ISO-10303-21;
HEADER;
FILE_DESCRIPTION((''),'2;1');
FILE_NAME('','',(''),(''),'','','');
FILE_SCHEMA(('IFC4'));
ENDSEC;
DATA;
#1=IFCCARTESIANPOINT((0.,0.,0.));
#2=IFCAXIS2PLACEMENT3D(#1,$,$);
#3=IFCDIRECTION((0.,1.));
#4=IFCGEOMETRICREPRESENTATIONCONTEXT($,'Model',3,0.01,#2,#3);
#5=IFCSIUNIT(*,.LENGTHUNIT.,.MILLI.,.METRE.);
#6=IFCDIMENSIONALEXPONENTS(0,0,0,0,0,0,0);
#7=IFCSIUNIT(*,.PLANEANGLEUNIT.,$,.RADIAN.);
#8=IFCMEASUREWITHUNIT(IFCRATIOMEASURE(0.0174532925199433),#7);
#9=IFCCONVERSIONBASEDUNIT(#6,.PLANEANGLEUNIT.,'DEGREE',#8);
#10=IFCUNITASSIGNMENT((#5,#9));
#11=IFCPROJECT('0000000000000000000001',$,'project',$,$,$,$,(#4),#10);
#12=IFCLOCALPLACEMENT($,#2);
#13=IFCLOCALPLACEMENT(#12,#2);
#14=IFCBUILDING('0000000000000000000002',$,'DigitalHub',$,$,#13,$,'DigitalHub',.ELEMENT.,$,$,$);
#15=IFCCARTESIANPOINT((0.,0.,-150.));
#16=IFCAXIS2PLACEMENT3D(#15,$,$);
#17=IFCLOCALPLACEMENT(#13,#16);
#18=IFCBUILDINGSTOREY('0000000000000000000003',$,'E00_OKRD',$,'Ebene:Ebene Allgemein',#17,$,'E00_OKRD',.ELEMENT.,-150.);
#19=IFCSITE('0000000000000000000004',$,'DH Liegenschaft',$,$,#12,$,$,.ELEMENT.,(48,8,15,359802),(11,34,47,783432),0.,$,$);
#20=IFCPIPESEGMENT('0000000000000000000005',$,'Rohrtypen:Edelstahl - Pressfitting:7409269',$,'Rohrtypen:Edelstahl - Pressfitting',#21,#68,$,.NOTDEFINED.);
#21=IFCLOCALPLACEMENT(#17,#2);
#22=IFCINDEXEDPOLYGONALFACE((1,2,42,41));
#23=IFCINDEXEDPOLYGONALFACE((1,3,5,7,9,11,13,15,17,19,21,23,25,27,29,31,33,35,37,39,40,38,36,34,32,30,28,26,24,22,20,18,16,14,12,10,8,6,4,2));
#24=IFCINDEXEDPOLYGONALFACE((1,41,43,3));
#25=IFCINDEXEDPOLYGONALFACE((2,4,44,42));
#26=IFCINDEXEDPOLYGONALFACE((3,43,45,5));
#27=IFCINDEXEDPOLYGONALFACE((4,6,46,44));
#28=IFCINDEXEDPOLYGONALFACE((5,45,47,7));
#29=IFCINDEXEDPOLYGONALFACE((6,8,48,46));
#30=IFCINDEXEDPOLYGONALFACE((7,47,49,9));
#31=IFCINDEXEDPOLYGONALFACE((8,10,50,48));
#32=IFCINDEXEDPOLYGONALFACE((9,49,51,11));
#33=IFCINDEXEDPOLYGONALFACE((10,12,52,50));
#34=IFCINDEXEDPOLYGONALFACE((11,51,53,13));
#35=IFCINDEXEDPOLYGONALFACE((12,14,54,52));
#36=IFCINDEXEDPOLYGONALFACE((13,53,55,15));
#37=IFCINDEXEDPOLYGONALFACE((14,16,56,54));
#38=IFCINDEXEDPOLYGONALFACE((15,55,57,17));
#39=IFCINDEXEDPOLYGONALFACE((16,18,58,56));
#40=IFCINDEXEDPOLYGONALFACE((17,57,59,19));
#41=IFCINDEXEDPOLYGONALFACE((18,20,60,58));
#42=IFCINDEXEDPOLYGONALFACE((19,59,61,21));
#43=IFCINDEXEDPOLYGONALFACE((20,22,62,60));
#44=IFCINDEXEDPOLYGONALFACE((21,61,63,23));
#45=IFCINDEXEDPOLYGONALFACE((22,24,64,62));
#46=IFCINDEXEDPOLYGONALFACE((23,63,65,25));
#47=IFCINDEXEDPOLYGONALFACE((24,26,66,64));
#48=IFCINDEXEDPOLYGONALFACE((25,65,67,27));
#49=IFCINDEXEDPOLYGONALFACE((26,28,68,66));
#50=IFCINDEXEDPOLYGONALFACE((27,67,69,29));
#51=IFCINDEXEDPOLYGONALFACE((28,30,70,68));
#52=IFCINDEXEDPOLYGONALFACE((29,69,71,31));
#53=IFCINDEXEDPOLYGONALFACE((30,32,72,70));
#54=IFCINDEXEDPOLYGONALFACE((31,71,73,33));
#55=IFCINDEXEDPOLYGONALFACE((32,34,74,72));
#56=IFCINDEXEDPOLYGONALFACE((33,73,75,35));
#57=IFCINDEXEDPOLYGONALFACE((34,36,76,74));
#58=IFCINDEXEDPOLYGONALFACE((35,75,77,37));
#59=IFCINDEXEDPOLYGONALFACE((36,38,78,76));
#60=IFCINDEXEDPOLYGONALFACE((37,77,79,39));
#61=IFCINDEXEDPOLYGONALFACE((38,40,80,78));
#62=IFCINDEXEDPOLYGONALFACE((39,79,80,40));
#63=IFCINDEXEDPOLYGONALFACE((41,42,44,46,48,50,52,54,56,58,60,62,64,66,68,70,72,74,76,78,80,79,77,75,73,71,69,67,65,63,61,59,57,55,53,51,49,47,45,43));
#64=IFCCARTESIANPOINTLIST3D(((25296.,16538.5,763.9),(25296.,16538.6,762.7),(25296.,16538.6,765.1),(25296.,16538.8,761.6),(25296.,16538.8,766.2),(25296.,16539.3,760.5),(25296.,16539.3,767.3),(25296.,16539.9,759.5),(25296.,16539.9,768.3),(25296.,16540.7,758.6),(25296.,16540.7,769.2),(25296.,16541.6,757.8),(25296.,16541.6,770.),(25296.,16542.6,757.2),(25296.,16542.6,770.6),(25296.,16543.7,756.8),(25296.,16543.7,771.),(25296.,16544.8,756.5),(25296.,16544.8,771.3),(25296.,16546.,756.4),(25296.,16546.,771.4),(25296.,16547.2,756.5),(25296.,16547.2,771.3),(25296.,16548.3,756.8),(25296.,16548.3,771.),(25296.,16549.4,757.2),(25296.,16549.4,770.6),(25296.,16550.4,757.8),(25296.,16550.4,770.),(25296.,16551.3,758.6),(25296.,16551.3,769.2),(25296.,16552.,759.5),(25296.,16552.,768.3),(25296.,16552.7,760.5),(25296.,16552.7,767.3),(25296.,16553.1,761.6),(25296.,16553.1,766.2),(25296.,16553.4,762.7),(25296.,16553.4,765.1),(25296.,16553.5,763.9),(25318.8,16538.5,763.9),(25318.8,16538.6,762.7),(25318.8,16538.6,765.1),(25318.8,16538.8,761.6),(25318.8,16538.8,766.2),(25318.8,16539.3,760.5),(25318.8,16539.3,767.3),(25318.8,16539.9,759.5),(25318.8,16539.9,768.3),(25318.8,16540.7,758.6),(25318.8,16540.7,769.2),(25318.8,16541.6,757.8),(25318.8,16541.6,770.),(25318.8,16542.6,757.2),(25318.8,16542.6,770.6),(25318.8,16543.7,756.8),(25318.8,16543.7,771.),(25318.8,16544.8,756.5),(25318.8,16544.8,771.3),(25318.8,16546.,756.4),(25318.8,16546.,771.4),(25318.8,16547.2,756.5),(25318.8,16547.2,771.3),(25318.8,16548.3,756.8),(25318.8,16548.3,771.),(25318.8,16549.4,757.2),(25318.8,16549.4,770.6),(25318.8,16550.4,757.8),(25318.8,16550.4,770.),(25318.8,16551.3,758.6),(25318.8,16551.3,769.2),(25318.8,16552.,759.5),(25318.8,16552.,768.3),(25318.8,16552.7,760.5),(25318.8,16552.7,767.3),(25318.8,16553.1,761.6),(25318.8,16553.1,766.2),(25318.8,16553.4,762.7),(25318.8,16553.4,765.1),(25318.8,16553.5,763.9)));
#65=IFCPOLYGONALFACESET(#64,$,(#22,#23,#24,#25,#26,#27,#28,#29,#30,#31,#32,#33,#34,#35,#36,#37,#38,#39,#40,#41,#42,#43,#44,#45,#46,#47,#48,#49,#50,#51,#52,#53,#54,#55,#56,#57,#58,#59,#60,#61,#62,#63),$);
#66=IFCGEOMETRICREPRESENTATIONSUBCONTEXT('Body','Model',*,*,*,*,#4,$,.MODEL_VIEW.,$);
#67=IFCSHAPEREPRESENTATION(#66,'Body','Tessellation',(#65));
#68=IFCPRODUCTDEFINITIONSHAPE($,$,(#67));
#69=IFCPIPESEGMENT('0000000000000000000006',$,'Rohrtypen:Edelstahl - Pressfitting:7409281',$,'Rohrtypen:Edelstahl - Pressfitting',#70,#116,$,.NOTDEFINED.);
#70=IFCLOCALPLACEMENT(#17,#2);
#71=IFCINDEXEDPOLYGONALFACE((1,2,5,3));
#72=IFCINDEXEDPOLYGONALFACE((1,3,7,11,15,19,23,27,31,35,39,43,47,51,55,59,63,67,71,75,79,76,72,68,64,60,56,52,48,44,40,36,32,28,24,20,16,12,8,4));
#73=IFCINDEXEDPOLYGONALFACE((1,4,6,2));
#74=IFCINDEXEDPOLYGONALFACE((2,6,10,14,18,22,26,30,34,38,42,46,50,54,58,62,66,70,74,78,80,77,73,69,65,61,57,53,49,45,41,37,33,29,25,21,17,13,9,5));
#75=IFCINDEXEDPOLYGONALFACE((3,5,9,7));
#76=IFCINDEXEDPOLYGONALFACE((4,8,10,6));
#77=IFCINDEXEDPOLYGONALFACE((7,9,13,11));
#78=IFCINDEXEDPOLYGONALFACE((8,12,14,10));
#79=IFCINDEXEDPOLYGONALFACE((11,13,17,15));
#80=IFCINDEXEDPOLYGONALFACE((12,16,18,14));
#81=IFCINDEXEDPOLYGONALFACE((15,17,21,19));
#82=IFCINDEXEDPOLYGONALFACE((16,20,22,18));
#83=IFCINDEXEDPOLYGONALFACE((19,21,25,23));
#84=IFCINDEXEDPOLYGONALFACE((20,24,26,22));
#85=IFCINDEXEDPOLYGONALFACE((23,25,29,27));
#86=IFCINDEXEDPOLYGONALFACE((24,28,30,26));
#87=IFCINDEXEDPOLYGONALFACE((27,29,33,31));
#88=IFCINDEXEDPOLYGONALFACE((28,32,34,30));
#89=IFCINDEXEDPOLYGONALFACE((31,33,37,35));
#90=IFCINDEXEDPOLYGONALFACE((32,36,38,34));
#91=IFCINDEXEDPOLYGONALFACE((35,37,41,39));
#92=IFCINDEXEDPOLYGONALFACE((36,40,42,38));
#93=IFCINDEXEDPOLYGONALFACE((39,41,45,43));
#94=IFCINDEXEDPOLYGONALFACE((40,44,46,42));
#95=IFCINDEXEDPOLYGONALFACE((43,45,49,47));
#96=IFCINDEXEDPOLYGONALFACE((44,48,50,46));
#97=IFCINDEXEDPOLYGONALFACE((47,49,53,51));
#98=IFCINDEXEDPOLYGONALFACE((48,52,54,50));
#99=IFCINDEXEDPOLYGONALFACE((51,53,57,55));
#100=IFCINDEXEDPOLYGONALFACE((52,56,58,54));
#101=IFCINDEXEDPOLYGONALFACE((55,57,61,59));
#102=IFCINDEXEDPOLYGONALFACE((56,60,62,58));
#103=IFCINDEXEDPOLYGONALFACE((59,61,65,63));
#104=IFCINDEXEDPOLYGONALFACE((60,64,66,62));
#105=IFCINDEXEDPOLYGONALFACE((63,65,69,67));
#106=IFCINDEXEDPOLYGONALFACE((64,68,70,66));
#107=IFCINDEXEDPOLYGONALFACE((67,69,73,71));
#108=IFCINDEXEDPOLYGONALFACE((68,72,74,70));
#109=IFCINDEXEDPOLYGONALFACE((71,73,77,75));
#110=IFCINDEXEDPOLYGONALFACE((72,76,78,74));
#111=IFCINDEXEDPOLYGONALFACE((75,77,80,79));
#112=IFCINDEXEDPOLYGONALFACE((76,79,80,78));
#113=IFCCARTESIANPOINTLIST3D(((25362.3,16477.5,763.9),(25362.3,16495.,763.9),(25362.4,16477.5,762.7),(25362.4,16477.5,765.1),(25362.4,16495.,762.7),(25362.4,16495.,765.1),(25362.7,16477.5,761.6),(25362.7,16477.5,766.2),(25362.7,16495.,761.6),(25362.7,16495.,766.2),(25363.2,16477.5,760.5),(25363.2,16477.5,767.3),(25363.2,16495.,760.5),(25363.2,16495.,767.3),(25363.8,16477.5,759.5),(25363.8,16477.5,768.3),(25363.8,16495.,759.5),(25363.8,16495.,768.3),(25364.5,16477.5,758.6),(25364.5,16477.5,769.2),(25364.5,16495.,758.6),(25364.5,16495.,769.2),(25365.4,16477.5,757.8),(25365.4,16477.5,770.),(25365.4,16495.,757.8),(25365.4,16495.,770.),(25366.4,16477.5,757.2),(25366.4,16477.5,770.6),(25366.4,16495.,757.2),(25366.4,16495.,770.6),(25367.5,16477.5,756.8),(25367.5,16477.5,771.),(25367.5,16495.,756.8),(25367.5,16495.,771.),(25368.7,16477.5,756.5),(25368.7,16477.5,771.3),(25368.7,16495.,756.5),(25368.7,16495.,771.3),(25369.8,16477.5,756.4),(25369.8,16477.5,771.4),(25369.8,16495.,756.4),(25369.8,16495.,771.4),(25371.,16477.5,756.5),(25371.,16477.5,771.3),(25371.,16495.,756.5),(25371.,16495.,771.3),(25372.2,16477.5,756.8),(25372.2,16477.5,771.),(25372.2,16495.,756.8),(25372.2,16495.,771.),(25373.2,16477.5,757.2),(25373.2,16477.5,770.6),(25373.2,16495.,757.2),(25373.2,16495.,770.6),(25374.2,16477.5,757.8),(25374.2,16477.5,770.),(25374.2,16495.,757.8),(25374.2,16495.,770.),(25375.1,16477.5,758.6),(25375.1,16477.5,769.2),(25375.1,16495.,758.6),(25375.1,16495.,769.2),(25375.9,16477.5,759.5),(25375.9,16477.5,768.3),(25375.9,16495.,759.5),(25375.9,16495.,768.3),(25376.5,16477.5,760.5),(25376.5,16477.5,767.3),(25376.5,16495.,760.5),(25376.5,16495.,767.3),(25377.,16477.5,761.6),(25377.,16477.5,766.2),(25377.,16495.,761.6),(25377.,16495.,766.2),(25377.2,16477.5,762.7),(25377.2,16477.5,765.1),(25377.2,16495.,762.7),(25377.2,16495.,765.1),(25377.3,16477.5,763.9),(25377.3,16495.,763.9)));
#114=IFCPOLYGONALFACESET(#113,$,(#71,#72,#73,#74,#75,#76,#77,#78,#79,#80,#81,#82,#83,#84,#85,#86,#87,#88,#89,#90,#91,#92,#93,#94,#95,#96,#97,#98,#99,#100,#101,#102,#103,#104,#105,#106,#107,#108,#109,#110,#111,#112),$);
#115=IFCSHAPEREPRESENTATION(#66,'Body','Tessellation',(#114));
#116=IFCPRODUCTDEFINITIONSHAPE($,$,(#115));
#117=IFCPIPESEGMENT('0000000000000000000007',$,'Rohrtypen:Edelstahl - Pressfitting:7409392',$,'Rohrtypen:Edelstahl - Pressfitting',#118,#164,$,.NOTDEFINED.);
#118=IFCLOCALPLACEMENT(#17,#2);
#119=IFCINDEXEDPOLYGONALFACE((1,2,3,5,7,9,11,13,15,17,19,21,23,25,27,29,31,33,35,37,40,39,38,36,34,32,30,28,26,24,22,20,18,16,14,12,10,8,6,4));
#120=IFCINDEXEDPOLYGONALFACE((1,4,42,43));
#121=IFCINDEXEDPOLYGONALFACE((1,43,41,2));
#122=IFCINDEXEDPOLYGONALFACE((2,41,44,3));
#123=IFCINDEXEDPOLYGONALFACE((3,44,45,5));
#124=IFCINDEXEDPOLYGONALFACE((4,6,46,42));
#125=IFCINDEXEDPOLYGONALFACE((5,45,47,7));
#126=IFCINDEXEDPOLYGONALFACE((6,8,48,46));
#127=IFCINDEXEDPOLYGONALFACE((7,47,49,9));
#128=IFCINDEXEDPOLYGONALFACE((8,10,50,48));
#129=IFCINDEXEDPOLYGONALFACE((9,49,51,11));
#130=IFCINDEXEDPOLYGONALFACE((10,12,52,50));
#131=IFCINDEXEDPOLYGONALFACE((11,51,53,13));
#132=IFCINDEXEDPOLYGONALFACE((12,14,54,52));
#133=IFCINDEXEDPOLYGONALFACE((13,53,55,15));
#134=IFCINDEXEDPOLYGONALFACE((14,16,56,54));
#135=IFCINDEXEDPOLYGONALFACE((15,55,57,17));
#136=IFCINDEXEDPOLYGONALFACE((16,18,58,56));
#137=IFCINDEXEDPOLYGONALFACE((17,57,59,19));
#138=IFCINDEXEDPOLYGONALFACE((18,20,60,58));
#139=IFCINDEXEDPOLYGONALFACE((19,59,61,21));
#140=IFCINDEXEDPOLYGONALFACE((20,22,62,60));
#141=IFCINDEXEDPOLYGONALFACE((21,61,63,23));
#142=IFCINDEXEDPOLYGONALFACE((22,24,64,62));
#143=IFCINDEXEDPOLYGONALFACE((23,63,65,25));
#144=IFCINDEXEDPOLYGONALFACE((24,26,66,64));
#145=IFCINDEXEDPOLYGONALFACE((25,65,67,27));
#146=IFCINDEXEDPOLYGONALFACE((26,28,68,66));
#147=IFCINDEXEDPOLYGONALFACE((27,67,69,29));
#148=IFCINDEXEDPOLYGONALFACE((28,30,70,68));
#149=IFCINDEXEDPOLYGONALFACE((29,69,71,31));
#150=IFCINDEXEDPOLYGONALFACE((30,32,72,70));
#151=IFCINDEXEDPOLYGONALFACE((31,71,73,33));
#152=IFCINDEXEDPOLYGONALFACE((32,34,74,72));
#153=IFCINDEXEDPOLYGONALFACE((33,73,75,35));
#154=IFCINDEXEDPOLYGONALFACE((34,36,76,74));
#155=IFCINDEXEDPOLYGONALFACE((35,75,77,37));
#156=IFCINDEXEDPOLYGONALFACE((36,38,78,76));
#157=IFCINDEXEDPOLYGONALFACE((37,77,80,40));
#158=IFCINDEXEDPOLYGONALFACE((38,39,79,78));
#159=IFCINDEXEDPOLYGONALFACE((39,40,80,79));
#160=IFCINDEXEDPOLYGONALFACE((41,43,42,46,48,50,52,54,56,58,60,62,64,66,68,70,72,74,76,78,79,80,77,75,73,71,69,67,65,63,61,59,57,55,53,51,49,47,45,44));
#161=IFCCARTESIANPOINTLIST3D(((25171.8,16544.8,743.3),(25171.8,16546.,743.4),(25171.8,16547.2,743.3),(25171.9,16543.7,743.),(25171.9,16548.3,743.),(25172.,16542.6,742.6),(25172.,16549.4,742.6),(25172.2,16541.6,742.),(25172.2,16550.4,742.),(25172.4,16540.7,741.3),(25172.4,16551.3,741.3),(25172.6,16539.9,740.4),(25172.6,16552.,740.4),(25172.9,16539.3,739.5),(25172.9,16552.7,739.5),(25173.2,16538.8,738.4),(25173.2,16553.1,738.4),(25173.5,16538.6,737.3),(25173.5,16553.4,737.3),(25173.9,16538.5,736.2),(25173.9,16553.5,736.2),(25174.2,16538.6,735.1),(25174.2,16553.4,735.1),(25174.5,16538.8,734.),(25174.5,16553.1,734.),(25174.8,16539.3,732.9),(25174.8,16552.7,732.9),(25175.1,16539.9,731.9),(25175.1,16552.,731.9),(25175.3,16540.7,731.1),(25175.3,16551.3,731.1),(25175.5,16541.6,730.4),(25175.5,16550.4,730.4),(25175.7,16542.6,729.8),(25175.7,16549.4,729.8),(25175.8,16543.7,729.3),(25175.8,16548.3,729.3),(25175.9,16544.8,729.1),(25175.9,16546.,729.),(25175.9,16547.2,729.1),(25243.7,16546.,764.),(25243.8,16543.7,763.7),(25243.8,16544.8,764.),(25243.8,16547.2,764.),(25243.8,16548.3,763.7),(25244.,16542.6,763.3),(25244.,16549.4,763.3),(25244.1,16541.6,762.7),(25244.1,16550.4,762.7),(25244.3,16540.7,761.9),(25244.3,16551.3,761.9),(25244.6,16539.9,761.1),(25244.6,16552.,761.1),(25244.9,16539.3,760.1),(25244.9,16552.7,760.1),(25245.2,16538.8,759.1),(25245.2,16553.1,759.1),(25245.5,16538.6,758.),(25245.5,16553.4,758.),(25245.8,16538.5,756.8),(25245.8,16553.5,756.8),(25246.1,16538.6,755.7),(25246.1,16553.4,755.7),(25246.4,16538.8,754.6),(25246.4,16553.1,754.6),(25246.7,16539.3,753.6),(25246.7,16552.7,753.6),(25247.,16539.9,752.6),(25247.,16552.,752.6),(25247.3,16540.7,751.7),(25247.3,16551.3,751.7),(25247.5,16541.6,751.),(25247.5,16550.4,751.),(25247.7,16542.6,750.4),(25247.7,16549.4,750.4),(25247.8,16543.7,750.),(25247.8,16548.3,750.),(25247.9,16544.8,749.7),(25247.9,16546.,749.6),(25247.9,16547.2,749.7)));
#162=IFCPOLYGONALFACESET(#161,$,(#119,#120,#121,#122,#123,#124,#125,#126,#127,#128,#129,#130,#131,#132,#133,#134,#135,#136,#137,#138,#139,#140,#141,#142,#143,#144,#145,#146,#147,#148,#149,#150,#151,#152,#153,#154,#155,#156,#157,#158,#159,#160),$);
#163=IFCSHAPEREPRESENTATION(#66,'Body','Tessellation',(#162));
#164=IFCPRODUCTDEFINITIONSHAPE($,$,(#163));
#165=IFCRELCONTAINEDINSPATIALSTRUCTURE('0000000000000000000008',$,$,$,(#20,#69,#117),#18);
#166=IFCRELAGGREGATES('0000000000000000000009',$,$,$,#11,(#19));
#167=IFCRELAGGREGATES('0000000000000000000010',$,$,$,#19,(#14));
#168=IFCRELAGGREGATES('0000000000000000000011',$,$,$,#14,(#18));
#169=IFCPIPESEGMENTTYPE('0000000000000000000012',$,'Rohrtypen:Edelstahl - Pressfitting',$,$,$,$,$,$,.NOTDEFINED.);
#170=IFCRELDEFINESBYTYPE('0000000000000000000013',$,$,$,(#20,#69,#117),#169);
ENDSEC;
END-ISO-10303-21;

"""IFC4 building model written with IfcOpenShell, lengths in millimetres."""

from ifc_helpers import new_model, entity, si_unit, converted_unit, direction, frame, origin, place, context, subcontext, project, spatial, indexed_curve, outline, extrude, type_object, element, save


model = new_model("IFC4")

# Units and contexts
model_context = context("Model", 3, precision=0.01, world=origin(), true_north=direction((0.0, 1.0)))
body_context = subcontext(model_context, "Body", "Model", "MODEL_VIEW")
ifc_project = project(units=[si_unit("LENGTHUNIT", "METRE", prefix="MILLI"), converted_unit("PLANEANGLEUNIT", "DEGREE", entity("IfcRatioMeasure", 0.0174532925199433), si_unit("PLANEANGLEUNIT", "RADIAN"), dimensions=[0, 0, 0, 0, 0, 0, 0])], contexts=[model_context])

# Site, building, storey
site_placement = place(None, origin())
site = spatial("IfcSite", under=ifc_project, at=site_placement, Name="DH Liegenschaft", CompositionType="ELEMENT", RefLatitude=(48, 8, 15, 359802), RefLongitude=(11, 34, 47, 783432), RefElevation=0.0)
building_placement = place(site_placement, origin())
building = spatial("IfcBuilding", under=site, at=building_placement, Name="DigitalHub", LongName="DigitalHub", CompositionType="ELEMENT")
storey_placement = place(building_placement, frame((0.0, 0.0, -150.0)))
storey = spatial("IfcBuildingStorey", under=building, at=storey_placement, Name="E00_OKRD", ObjectType="Ebene:Ebene Allgemein", LongName="E00_OKRD", CompositionType="ELEMENT", Elevation=-150.0)

# Pipe segments
pipe_segment_type_1 = type_object("IfcPipeSegmentType", Name="Rohrtypen:Edelstahl - Pressfitting", PredefinedType="NOTDEFINED")
pipe_segment_1_placement = place(storey_placement, frame((25296.0, 16536.9, 754.8)))
element("IfcPipeSegment", 1, at=pipe_segment_1_placement, inside=storey, type_object=pipe_segment_type_1, Name="Rohrtypen:Edelstahl - Pressfitting:7409269", ObjectType="Rohrtypen:Edelstahl - Pressfitting", PredefinedType="NOTDEFINED", context=body_context, shape_type="SweptSolid", body=[
    extrude(outline(indexed_curve([(7.5, 0.0), (7.4, 1.2), (7.1, 2.3), (6.7, 3.4), (6.1, 4.4), (5.3, 5.3), (4.4, 6.1), (3.4, 6.7), (2.3, 7.1), (1.2, 7.4), (0.0, 7.5), (-1.2, 7.4), (-2.3, 7.1), (-3.4, 6.7), (-4.4, 6.1), (-5.3, 5.3), (-6.1, 4.4), (-6.7, 3.4), (-7.1, 2.3), (-7.4, 1.2), (-7.5, 0.0), (-7.4, -1.2), (-7.1, -2.3), (-6.7, -3.4), (-6.1, -4.4), (-5.3, -5.3), (-4.4, -6.1), (-3.4, -6.7), (-2.3, -7.1), (-1.2, -7.4), (0.0, -7.5), (1.2, -7.4), (2.3, -7.1), (3.4, -6.7), (4.4, -6.1), (5.3, -5.3), (6.1, -4.4), (6.7, -3.4), (7.1, -2.3), (7.4, -1.2), (7.5, 0.0)], self_intersect=False)), frame((0.0, 9.1, 9.1), z_axis=(1.0, 0.0, 0.0), x_axis=(0.0, 1.0, 0.0)), (0.0, 0.0, 1.0), 22.8),
])
pipe_segment_2_placement = place(storey_placement, frame((25360.7, 16477.5, 754.8)))
element("IfcPipeSegment", 2, at=pipe_segment_2_placement, inside=storey, type_object=pipe_segment_type_1, Name="Rohrtypen:Edelstahl - Pressfitting:7409281", ObjectType="Rohrtypen:Edelstahl - Pressfitting", PredefinedType="NOTDEFINED", context=body_context, shape_type="SweptSolid", body=[
    extrude(outline(indexed_curve([(7.5, 0.0), (7.4, 1.2), (7.1, 2.3), (6.7, 3.4), (6.1, 4.4), (5.3, 5.3), (4.4, 6.1), (3.4, 6.7), (2.3, 7.1), (1.2, 7.4), (0.0, 7.5), (-1.2, 7.4), (-2.3, 7.1), (-3.4, 6.7), (-4.4, 6.1), (-5.3, 5.3), (-6.1, 4.4), (-6.7, 3.4), (-7.1, 2.3), (-7.4, 1.2), (-7.5, 0.0), (-7.4, -1.2), (-7.1, -2.3), (-6.7, -3.4), (-6.1, -4.4), (-5.3, -5.3), (-4.4, -6.1), (-3.4, -6.7), (-2.3, -7.1), (-1.2, -7.4), (0.0, -7.5), (1.2, -7.4), (2.3, -7.1), (3.4, -6.7), (4.4, -6.1), (5.3, -5.3), (6.1, -4.4), (6.7, -3.4), (7.1, -2.3), (7.4, -1.2), (7.5, 0.0)], self_intersect=False)), frame((9.1, 0.0, 9.1), z_axis=(0.0, 1.0, 0.0), x_axis=(1.0, 0.0, 0.0)), (0.0, 0.0, 1.0), 17.4),
])
pipe_segment_3_placement = place(storey_placement, frame((25170.2, 16536.9, 727.4)))
element("IfcPipeSegment", 3, at=pipe_segment_3_placement, inside=storey, type_object=pipe_segment_type_1, Name="Rohrtypen:Edelstahl - Pressfitting:7409392", ObjectType="Rohrtypen:Edelstahl - Pressfitting", PredefinedType="NOTDEFINED", context=body_context, shape_type="SweptSolid", body=[
    extrude(outline(indexed_curve([(7.5, 0.0), (7.4, 1.2), (7.1, 2.3), (6.7, 3.4), (6.1, 4.4), (5.3, 5.3), (4.4, 6.1), (3.4, 6.7), (2.3, 7.1), (1.2, 7.4), (0.0, 7.5), (-1.2, 7.4), (-2.3, 7.1), (-3.4, 6.7), (-4.4, 6.1), (-5.3, 5.3), (-6.1, 4.4), (-6.7, 3.4), (-7.1, 2.3), (-7.4, 1.2), (-7.5, 0.0), (-7.4, -1.2), (-7.1, -2.3), (-6.7, -3.4), (-6.1, -4.4), (-5.3, -5.3), (-4.4, -6.1), (-3.4, -6.7), (-2.3, -7.1), (-1.2, -7.4), (0.0, -7.5), (1.2, -7.4), (2.3, -7.1), (3.4, -6.7), (4.4, -6.1), (5.3, -5.3), (6.1, -4.4), (6.7, -3.4), (7.1, -2.3), (7.4, -1.2), (7.5, 0.0)], self_intersect=False)), frame((3.7, 9.1, 8.8), z_axis=(0.961197, 0.0, 0.275863), x_axis=(0.0, 1.0, 0.0)), (0.0, 0.0, 1.0), 74.8),
])

save(model, "model.ifc")
